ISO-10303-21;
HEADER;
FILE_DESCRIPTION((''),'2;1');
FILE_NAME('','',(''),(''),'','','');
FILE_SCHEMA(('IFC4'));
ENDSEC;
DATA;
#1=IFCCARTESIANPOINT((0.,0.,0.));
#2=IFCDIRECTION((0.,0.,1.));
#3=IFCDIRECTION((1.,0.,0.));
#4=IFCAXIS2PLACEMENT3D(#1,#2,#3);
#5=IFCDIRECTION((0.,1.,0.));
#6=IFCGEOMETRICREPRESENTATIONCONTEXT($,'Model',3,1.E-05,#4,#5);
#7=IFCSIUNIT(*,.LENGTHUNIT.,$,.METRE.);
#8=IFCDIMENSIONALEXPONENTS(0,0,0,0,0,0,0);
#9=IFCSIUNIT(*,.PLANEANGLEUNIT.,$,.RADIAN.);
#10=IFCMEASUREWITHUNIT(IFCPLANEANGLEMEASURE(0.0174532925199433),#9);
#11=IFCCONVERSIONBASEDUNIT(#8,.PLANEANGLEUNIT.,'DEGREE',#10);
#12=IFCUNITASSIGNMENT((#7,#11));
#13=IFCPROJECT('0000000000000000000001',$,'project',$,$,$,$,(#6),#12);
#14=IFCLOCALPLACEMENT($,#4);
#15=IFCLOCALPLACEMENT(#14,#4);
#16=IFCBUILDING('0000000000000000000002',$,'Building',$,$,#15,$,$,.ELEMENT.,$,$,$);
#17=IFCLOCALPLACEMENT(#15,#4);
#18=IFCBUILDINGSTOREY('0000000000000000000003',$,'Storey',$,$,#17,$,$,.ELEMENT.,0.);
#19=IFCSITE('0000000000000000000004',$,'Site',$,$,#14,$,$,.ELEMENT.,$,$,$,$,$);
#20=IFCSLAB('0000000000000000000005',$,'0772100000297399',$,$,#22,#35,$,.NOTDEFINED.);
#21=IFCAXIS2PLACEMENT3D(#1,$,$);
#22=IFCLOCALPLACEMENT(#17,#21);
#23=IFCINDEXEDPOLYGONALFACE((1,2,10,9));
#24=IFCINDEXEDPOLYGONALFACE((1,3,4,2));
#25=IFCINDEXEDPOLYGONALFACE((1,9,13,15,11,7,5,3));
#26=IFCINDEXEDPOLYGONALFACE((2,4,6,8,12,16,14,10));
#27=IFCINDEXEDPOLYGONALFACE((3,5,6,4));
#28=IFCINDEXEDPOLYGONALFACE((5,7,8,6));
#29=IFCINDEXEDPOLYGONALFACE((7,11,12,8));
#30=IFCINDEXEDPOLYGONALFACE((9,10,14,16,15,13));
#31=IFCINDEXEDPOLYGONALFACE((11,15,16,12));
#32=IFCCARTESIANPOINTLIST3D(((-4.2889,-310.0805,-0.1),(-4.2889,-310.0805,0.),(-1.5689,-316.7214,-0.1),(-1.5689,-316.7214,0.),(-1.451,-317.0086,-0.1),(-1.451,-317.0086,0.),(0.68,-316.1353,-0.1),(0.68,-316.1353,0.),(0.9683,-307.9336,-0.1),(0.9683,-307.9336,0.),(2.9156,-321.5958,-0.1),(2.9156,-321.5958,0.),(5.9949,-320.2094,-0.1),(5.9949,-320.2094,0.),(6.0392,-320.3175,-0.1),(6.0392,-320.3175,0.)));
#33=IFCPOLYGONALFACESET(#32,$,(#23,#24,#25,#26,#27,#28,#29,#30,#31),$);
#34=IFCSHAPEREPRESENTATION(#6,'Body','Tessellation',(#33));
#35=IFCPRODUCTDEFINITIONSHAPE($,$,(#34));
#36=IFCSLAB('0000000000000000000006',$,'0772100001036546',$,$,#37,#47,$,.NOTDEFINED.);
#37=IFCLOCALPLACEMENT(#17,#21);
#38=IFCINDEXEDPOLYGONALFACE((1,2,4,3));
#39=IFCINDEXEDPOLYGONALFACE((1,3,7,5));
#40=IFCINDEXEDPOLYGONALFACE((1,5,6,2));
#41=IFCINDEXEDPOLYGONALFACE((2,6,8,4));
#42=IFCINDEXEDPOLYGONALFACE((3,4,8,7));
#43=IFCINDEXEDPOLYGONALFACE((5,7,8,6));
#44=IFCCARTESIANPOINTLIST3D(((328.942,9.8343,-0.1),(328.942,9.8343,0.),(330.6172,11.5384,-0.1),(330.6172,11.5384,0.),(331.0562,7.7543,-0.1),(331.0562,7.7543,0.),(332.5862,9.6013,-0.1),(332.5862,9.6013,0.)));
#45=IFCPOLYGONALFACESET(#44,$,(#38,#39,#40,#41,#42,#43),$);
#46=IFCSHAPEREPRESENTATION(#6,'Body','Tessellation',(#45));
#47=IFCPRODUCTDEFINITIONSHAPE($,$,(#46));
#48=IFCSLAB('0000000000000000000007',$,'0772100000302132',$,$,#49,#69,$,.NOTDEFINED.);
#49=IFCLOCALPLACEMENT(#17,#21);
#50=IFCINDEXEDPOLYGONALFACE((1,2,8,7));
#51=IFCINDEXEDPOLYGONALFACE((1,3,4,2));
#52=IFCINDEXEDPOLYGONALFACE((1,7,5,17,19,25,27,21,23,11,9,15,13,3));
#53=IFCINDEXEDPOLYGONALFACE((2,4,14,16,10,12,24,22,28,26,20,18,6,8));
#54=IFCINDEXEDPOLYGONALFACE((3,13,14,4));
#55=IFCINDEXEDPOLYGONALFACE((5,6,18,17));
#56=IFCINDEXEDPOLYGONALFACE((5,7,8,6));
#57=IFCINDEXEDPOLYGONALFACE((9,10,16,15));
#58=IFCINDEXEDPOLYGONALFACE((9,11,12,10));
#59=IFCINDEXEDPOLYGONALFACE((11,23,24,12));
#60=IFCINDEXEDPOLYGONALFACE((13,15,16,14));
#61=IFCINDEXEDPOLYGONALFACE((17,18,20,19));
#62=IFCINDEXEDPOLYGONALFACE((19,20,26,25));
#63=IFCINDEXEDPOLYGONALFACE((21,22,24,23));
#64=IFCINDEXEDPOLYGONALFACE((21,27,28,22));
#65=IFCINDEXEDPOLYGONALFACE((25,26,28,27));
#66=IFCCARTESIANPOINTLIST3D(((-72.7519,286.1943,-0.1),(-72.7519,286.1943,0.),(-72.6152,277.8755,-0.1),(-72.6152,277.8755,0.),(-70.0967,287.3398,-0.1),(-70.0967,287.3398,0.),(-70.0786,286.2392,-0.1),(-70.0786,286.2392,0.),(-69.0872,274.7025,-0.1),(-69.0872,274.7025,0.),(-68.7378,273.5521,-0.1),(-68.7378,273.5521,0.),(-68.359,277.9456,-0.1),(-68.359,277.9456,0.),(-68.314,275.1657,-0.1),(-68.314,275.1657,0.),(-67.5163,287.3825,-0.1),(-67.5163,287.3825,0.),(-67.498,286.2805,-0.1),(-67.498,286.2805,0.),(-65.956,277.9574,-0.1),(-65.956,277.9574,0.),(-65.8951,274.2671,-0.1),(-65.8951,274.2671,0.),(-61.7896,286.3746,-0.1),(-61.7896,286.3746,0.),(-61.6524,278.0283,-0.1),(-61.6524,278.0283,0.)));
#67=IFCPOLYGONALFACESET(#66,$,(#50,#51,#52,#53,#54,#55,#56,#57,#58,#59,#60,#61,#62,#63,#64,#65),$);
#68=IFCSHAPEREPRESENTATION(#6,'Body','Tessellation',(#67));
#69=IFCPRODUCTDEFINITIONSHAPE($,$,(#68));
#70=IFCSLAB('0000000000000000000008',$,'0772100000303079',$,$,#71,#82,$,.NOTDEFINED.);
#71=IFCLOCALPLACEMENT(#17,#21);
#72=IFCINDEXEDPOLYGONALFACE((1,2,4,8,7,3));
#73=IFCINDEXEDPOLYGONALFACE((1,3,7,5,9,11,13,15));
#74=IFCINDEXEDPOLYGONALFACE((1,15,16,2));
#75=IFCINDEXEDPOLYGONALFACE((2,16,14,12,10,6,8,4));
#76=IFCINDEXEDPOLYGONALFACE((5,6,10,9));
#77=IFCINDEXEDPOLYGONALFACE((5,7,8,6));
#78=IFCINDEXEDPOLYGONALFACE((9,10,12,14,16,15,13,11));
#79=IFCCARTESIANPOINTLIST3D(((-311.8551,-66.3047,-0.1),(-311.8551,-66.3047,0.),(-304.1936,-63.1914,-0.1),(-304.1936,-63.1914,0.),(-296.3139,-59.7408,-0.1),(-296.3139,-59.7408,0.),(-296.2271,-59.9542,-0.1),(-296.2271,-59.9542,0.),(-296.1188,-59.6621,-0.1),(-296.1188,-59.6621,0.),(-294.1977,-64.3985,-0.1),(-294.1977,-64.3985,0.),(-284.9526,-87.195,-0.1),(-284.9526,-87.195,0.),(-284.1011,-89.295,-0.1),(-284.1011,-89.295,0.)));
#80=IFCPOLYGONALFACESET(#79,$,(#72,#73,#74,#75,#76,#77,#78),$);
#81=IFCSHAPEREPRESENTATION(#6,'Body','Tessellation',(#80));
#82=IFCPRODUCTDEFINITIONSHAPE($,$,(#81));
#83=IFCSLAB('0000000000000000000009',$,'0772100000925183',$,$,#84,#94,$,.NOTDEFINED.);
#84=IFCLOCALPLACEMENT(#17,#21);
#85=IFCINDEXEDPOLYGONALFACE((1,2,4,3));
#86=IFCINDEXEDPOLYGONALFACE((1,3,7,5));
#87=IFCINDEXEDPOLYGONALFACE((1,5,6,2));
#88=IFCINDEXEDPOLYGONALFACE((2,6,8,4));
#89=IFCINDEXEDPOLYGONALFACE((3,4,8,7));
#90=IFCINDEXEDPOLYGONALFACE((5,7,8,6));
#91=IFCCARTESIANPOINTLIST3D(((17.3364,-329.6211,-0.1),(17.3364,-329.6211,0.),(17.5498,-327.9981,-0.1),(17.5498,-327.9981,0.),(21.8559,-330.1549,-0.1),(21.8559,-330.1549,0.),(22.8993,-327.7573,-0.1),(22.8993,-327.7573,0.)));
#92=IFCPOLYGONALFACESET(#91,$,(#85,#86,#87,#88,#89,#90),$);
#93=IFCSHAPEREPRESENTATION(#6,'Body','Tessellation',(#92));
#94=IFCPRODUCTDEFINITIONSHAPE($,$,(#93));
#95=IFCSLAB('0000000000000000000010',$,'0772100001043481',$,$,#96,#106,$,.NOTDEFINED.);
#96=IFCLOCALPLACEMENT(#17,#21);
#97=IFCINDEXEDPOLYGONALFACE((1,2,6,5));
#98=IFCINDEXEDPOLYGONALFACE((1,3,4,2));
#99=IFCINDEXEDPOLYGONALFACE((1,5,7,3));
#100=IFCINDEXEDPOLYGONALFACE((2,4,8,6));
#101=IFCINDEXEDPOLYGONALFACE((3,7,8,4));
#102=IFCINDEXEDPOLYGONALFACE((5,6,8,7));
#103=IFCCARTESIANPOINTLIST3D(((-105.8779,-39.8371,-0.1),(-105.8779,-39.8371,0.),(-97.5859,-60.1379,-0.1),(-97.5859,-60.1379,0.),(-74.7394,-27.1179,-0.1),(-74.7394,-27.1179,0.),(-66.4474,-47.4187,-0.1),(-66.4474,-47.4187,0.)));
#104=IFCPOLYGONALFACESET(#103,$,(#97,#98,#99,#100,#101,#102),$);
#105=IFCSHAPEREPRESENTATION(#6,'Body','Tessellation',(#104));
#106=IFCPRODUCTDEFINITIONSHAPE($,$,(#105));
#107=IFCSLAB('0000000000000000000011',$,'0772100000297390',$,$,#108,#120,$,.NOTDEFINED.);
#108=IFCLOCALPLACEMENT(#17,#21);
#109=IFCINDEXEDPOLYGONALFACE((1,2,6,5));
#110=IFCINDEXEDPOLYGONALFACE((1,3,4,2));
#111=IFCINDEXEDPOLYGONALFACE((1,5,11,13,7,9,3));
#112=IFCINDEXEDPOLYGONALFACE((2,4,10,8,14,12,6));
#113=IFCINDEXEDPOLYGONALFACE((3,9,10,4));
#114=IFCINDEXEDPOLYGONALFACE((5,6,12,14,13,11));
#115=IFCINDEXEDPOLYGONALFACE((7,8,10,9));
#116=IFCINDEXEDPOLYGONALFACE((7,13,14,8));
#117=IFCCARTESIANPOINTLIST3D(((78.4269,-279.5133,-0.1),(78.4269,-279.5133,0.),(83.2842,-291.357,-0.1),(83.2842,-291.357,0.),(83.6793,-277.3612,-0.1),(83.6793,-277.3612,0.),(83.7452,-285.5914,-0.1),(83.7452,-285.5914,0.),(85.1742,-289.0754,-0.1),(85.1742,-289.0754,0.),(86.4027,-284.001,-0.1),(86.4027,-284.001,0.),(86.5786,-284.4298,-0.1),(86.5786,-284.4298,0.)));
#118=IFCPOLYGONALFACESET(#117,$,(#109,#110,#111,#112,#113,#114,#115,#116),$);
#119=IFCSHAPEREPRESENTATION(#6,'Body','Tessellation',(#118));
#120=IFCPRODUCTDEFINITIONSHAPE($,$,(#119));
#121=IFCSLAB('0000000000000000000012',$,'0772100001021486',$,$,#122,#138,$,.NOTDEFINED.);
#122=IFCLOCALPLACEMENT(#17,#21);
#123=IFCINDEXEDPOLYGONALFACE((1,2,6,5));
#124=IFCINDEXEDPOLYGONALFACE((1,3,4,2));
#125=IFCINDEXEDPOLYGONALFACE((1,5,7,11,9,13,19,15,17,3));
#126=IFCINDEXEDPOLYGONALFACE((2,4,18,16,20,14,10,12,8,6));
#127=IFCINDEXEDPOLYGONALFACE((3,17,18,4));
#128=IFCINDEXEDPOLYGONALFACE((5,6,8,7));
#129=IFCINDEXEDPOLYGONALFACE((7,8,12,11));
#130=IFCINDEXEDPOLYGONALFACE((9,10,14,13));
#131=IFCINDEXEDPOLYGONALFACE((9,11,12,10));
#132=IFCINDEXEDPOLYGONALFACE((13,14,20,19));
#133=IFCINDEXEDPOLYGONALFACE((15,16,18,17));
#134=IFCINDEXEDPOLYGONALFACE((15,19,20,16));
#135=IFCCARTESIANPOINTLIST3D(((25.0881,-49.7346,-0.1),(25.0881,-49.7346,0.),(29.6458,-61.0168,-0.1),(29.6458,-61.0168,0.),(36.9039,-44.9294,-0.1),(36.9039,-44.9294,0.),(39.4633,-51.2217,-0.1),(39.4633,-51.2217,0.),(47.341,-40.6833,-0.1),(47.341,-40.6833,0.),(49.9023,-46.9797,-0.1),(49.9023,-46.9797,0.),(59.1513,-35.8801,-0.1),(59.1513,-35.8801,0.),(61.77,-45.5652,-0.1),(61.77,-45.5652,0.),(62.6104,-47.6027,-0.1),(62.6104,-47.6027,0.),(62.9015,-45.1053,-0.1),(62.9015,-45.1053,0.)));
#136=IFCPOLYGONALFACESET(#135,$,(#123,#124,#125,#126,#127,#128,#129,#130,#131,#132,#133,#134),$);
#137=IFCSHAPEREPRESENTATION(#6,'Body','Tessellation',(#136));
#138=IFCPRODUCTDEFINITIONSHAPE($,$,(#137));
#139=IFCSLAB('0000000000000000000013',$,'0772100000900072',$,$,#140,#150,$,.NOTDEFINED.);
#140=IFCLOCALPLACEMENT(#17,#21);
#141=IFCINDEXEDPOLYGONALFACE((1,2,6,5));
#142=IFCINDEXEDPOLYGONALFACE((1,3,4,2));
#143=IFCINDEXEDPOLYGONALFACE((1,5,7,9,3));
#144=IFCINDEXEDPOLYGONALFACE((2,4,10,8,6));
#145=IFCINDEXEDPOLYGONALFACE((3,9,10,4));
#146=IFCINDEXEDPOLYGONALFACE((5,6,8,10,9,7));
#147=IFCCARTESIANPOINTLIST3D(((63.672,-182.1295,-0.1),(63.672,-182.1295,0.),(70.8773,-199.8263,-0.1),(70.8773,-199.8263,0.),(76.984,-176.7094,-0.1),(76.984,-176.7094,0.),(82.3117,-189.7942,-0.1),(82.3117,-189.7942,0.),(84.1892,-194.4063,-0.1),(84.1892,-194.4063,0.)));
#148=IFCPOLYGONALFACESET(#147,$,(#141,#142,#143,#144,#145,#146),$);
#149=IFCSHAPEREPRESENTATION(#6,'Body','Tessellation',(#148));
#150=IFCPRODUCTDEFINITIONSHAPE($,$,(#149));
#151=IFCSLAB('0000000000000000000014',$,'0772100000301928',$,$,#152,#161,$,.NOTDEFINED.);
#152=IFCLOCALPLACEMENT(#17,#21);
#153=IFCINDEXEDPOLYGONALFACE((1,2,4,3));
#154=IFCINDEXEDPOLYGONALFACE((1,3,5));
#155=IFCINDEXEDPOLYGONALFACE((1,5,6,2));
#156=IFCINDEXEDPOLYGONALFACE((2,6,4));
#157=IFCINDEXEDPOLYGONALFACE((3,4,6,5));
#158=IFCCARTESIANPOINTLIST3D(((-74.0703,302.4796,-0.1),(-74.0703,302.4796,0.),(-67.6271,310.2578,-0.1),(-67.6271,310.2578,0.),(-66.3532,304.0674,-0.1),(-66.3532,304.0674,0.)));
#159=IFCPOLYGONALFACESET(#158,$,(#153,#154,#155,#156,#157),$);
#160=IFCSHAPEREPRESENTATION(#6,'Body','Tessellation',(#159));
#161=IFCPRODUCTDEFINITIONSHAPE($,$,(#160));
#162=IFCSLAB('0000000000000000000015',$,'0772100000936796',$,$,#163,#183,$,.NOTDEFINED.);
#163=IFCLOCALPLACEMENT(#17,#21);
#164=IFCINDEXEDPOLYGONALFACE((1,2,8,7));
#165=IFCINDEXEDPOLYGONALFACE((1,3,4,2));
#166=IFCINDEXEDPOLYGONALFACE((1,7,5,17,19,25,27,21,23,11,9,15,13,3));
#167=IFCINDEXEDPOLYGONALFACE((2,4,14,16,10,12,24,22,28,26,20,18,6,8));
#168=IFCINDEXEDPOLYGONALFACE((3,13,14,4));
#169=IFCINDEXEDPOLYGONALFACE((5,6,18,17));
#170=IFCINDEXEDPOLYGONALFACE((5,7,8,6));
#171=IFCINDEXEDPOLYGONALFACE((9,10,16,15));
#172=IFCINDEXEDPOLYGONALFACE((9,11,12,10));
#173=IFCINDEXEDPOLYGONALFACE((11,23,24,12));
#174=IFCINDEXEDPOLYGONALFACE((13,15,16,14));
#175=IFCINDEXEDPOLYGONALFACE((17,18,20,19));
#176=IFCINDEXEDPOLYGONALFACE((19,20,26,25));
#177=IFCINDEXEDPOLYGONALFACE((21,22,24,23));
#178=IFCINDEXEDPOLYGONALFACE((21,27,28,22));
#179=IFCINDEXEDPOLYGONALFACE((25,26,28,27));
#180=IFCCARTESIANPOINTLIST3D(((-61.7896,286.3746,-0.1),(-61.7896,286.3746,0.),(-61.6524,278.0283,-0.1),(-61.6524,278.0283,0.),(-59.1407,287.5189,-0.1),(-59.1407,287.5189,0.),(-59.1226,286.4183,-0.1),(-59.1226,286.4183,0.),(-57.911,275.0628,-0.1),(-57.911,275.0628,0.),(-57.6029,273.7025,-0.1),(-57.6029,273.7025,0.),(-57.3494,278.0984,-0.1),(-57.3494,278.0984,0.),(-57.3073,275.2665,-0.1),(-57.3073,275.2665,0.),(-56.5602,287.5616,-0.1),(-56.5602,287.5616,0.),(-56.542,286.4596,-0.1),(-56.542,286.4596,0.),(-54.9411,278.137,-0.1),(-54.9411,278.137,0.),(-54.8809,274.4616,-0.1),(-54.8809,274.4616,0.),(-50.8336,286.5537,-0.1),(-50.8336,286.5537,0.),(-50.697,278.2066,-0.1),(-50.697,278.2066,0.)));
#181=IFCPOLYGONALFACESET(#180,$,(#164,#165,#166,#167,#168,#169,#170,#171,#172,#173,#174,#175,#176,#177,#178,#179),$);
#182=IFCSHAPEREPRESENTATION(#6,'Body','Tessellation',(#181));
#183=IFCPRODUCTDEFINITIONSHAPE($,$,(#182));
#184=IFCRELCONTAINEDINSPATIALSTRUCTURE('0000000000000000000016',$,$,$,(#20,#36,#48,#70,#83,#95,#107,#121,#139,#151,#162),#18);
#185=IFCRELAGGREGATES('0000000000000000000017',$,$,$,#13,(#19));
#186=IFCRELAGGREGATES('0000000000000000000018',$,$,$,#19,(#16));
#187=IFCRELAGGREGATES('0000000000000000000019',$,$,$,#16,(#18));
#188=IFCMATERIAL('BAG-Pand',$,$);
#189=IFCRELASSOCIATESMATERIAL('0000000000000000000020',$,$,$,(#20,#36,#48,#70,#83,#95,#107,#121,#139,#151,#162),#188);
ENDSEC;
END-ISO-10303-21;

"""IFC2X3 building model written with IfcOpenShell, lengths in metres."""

from ifc_helpers import new_model, entity, si_unit, converted_unit, direction, frame, origin_with_axes, place, context, project, spatial, polyline, outline, extrude, material, element, save


model = new_model("IFC2X3")

# Units and contexts
model_context = context("Model", 3, precision=1e-05, world=origin_with_axes(), true_north=direction((0.0, 1.0, 0.0)))
ifc_project = project(units=[si_unit("LENGTHUNIT", "METRE"), converted_unit("PLANEANGLEUNIT", "DEGREE", entity("IfcPlaneAngleMeasure", 0.0174532925199433), si_unit("PLANEANGLEUNIT", "RADIAN"), dimensions=[0, 0, 0, 0, 0, 0, 0])], contexts=[model_context])

# Site, building, storey
site_placement = place(None, origin_with_axes())
site = spatial("IfcSite", under=ifc_project, at=site_placement, Name="Site", CompositionType="ELEMENT")
building_placement = place(site_placement, origin_with_axes())
building = spatial("IfcBuilding", under=site, at=building_placement, Name="Building", CompositionType="ELEMENT")
storey_placement = place(building_placement, origin_with_axes())
storey = spatial("IfcBuildingStorey", under=building, at=storey_placement, Name="Storey", CompositionType="ELEMENT", Elevation=0.0)

# Slabs
ifc_material = material(Name="BAG-Pand")
slab_1_placement = place(storey_placement, frame((0.0, 0.0, -0.1), z_axis=(0.0, 0.0, 1.0), x_axis=(1.0, 0.0, 0.0)))
element("IfcSlab", 1, at=slab_1_placement, inside=storey, material=ifc_material, Name="0772100000297399", PredefinedType="NOTDEFINED", context=model_context, shape_type="SweptSolid", body=[
    extrude(outline(polyline([(0.9683, -307.9336), (5.9949, -320.2094), (6.0392, -320.3175), (2.9156, -321.5958), (0.68, -316.1353), (-1.451, -317.0086), (-1.5689, -316.7214), (-4.2889, -310.0805), (0.9683, -307.9336)])), origin_with_axes(), (0.0, 0.0, 1.0), 0.1),
])
slab_2_placement = place(storey_placement, frame((0.0, 0.0, -0.1), z_axis=(0.0, 0.0, 1.0), x_axis=(1.0, 0.0, 0.0)))
element("IfcSlab", 2, at=slab_2_placement, inside=storey, material=ifc_material, Name="0772100001036546", PredefinedType="NOTDEFINED", context=model_context, shape_type="SweptSolid", body=[
    extrude(outline(polyline([(328.942, 9.8343), (330.6172, 11.5384), (332.5862, 9.6013), (331.0562, 7.7543), (328.942, 9.8343)])), origin_with_axes(), (0.0, 0.0, 1.0), 0.1),
])
slab_3_placement = place(storey_placement, frame((0.0, 0.0, -0.1), z_axis=(0.0, 0.0, 1.0), x_axis=(1.0, 0.0, 0.0)))
element("IfcSlab", 3, at=slab_3_placement, inside=storey, material=ifc_material, Name="0772100000302132", PredefinedType="NOTDEFINED", context=model_context, shape_type="SweptSolid", body=[
    extrude(outline(polyline([(-69.0872, 274.7025), (-68.314, 275.1657), (-68.359, 277.9456), (-72.6152, 277.8755), (-72.7519, 286.1943), (-70.0786, 286.2392), (-70.0967, 287.3398), (-67.5163, 287.3825), (-67.498, 286.2805), (-61.7896, 286.3746), (-61.6524, 278.0283), (-65.956, 277.9574), (-65.8951, 274.2671), (-68.7378, 273.5521), (-69.0872, 274.7025)])), origin_with_axes(), (0.0, 0.0, 1.0), 0.1),
])
slab_4_placement = place(storey_placement, frame((0.0, 0.0, -0.1), z_axis=(0.0, 0.0, 1.0), x_axis=(1.0, 0.0, 0.0)))
element("IfcSlab", 4, at=slab_4_placement, inside=storey, material=ifc_material, Name="0772100000303079", PredefinedType="NOTDEFINED", context=model_context, shape_type="SweptSolid", body=[
    extrude(outline(polyline([(-304.1936, -63.1914), (-296.2271, -59.9542), (-296.3139, -59.7408), (-296.1188, -59.6621), (-294.1977, -64.3985), (-284.9526, -87.195), (-284.1011, -89.295), (-311.8551, -66.3047), (-304.1936, -63.1914)])), origin_with_axes(), (0.0, 0.0, 1.0), 0.1),
])
slab_5_placement = place(storey_placement, frame((0.0, 0.0, -0.1), z_axis=(0.0, 0.0, 1.0), x_axis=(1.0, 0.0, 0.0)))
element("IfcSlab", 5, at=slab_5_placement, inside=storey, material=ifc_material, Name="0772100000925183", PredefinedType="NOTDEFINED", context=model_context, shape_type="SweptSolid", body=[
    extrude(outline(polyline([(22.8993, -327.7573), (21.8559, -330.1549), (17.3364, -329.6211), (17.5498, -327.9981), (22.8993, -327.7573)])), origin_with_axes(), (0.0, 0.0, 1.0), 0.1),
])
slab_6_placement = place(storey_placement, frame((0.0, 0.0, -0.1), z_axis=(0.0, 0.0, 1.0), x_axis=(1.0, 0.0, 0.0)))
element("IfcSlab", 6, at=slab_6_placement, inside=storey, material=ifc_material, Name="0772100001043481", PredefinedType="NOTDEFINED", context=model_context, shape_type="SweptSolid", body=[
    extrude(outline(polyline([(-105.8779, -39.8371), (-74.7394, -27.1179), (-66.4474, -47.4187), (-97.5859, -60.1379), (-105.8779, -39.8371)])), origin_with_axes(), (0.0, 0.0, 1.0), 0.1),
])
slab_7_placement = place(storey_placement, frame((0.0, 0.0, -0.1), z_axis=(0.0, 0.0, 1.0), x_axis=(1.0, 0.0, 0.0)))
element("IfcSlab", 7, at=slab_7_placement, inside=storey, material=ifc_material, Name="0772100000297390", PredefinedType="NOTDEFINED", context=model_context, shape_type="SweptSolid", body=[
    extrude(outline(polyline([(78.4269, -279.5133), (83.6793, -277.3612), (86.4027, -284.001), (86.5786, -284.4298), (83.7452, -285.5914), (85.1742, -289.0754), (83.2842, -291.357), (78.4269, -279.5133)])), origin_with_axes(), (0.0, 0.0, 1.0), 0.1),
])
slab_8_placement = place(storey_placement, frame((0.0, 0.0, -0.1), z_axis=(0.0, 0.0, 1.0), x_axis=(1.0, 0.0, 0.0)))
element("IfcSlab", 8, at=slab_8_placement, inside=storey, material=ifc_material, Name="0772100001021486", PredefinedType="NOTDEFINED", context=model_context, shape_type="SweptSolid", body=[
    extrude(outline(polyline([(25.0881, -49.7346), (36.9039, -44.9294), (39.4633, -51.2217), (49.9023, -46.9797), (47.341, -40.6833), (59.1513, -35.8801), (62.9015, -45.1053), (61.77, -45.5652), (62.6104, -47.6027), (29.6458, -61.0168), (25.0881, -49.7346)])), origin_with_axes(), (0.0, 0.0, 1.0), 0.1),
])
slab_9_placement = place(storey_placement, frame((0.0, 0.0, -0.1), z_axis=(0.0, 0.0, 1.0), x_axis=(1.0, 0.0, 0.0)))
element("IfcSlab", 9, at=slab_9_placement, inside=storey, material=ifc_material, Name="0772100000900072", PredefinedType="NOTDEFINED", context=model_context, shape_type="SweptSolid", body=[
    extrude(outline(polyline([(63.672, -182.1295), (76.984, -176.7094), (82.3117, -189.7942), (84.1892, -194.4063), (70.8773, -199.8263), (63.672, -182.1295)])), origin_with_axes(), (0.0, 0.0, 1.0), 0.1),
])
slab_10_placement = place(storey_placement, frame((0.0, 0.0, -0.1), z_axis=(0.0, 0.0, 1.0), x_axis=(1.0, 0.0, 0.0)))
element("IfcSlab", 10, at=slab_10_placement, inside=storey, material=ifc_material, Name="0772100000301928", PredefinedType="NOTDEFINED", context=model_context, shape_type="SweptSolid", body=[
    extrude(outline(polyline([(-66.3532, 304.0674), (-74.0703, 302.4796), (-67.6271, 310.2578), (-66.3532, 304.0674)])), origin_with_axes(), (0.0, 0.0, 1.0), 0.1),
])
slab_11_placement = place(storey_placement, frame((0.0, 0.0, -0.1), z_axis=(0.0, 0.0, 1.0), x_axis=(1.0, 0.0, 0.0)))
element("IfcSlab", 11, at=slab_11_placement, inside=storey, material=ifc_material, Name="0772100000936796", PredefinedType="NOTDEFINED", context=model_context, shape_type="SweptSolid", body=[
    extrude(outline(polyline([(-57.911, 275.0628), (-57.3073, 275.2665), (-57.3494, 278.0984), (-61.6524, 278.0283), (-61.7896, 286.3746), (-59.1226, 286.4183), (-59.1407, 287.5189), (-56.5602, 287.5616), (-56.542, 286.4596), (-50.8336, 286.5537), (-50.697, 278.2066), (-54.9411, 278.137), (-54.8809, 274.4616), (-57.6029, 273.7025), (-57.911, 275.0628)])), origin_with_axes(), (0.0, 0.0, 1.0), 0.1),
])

save(model, "model.ifc")
